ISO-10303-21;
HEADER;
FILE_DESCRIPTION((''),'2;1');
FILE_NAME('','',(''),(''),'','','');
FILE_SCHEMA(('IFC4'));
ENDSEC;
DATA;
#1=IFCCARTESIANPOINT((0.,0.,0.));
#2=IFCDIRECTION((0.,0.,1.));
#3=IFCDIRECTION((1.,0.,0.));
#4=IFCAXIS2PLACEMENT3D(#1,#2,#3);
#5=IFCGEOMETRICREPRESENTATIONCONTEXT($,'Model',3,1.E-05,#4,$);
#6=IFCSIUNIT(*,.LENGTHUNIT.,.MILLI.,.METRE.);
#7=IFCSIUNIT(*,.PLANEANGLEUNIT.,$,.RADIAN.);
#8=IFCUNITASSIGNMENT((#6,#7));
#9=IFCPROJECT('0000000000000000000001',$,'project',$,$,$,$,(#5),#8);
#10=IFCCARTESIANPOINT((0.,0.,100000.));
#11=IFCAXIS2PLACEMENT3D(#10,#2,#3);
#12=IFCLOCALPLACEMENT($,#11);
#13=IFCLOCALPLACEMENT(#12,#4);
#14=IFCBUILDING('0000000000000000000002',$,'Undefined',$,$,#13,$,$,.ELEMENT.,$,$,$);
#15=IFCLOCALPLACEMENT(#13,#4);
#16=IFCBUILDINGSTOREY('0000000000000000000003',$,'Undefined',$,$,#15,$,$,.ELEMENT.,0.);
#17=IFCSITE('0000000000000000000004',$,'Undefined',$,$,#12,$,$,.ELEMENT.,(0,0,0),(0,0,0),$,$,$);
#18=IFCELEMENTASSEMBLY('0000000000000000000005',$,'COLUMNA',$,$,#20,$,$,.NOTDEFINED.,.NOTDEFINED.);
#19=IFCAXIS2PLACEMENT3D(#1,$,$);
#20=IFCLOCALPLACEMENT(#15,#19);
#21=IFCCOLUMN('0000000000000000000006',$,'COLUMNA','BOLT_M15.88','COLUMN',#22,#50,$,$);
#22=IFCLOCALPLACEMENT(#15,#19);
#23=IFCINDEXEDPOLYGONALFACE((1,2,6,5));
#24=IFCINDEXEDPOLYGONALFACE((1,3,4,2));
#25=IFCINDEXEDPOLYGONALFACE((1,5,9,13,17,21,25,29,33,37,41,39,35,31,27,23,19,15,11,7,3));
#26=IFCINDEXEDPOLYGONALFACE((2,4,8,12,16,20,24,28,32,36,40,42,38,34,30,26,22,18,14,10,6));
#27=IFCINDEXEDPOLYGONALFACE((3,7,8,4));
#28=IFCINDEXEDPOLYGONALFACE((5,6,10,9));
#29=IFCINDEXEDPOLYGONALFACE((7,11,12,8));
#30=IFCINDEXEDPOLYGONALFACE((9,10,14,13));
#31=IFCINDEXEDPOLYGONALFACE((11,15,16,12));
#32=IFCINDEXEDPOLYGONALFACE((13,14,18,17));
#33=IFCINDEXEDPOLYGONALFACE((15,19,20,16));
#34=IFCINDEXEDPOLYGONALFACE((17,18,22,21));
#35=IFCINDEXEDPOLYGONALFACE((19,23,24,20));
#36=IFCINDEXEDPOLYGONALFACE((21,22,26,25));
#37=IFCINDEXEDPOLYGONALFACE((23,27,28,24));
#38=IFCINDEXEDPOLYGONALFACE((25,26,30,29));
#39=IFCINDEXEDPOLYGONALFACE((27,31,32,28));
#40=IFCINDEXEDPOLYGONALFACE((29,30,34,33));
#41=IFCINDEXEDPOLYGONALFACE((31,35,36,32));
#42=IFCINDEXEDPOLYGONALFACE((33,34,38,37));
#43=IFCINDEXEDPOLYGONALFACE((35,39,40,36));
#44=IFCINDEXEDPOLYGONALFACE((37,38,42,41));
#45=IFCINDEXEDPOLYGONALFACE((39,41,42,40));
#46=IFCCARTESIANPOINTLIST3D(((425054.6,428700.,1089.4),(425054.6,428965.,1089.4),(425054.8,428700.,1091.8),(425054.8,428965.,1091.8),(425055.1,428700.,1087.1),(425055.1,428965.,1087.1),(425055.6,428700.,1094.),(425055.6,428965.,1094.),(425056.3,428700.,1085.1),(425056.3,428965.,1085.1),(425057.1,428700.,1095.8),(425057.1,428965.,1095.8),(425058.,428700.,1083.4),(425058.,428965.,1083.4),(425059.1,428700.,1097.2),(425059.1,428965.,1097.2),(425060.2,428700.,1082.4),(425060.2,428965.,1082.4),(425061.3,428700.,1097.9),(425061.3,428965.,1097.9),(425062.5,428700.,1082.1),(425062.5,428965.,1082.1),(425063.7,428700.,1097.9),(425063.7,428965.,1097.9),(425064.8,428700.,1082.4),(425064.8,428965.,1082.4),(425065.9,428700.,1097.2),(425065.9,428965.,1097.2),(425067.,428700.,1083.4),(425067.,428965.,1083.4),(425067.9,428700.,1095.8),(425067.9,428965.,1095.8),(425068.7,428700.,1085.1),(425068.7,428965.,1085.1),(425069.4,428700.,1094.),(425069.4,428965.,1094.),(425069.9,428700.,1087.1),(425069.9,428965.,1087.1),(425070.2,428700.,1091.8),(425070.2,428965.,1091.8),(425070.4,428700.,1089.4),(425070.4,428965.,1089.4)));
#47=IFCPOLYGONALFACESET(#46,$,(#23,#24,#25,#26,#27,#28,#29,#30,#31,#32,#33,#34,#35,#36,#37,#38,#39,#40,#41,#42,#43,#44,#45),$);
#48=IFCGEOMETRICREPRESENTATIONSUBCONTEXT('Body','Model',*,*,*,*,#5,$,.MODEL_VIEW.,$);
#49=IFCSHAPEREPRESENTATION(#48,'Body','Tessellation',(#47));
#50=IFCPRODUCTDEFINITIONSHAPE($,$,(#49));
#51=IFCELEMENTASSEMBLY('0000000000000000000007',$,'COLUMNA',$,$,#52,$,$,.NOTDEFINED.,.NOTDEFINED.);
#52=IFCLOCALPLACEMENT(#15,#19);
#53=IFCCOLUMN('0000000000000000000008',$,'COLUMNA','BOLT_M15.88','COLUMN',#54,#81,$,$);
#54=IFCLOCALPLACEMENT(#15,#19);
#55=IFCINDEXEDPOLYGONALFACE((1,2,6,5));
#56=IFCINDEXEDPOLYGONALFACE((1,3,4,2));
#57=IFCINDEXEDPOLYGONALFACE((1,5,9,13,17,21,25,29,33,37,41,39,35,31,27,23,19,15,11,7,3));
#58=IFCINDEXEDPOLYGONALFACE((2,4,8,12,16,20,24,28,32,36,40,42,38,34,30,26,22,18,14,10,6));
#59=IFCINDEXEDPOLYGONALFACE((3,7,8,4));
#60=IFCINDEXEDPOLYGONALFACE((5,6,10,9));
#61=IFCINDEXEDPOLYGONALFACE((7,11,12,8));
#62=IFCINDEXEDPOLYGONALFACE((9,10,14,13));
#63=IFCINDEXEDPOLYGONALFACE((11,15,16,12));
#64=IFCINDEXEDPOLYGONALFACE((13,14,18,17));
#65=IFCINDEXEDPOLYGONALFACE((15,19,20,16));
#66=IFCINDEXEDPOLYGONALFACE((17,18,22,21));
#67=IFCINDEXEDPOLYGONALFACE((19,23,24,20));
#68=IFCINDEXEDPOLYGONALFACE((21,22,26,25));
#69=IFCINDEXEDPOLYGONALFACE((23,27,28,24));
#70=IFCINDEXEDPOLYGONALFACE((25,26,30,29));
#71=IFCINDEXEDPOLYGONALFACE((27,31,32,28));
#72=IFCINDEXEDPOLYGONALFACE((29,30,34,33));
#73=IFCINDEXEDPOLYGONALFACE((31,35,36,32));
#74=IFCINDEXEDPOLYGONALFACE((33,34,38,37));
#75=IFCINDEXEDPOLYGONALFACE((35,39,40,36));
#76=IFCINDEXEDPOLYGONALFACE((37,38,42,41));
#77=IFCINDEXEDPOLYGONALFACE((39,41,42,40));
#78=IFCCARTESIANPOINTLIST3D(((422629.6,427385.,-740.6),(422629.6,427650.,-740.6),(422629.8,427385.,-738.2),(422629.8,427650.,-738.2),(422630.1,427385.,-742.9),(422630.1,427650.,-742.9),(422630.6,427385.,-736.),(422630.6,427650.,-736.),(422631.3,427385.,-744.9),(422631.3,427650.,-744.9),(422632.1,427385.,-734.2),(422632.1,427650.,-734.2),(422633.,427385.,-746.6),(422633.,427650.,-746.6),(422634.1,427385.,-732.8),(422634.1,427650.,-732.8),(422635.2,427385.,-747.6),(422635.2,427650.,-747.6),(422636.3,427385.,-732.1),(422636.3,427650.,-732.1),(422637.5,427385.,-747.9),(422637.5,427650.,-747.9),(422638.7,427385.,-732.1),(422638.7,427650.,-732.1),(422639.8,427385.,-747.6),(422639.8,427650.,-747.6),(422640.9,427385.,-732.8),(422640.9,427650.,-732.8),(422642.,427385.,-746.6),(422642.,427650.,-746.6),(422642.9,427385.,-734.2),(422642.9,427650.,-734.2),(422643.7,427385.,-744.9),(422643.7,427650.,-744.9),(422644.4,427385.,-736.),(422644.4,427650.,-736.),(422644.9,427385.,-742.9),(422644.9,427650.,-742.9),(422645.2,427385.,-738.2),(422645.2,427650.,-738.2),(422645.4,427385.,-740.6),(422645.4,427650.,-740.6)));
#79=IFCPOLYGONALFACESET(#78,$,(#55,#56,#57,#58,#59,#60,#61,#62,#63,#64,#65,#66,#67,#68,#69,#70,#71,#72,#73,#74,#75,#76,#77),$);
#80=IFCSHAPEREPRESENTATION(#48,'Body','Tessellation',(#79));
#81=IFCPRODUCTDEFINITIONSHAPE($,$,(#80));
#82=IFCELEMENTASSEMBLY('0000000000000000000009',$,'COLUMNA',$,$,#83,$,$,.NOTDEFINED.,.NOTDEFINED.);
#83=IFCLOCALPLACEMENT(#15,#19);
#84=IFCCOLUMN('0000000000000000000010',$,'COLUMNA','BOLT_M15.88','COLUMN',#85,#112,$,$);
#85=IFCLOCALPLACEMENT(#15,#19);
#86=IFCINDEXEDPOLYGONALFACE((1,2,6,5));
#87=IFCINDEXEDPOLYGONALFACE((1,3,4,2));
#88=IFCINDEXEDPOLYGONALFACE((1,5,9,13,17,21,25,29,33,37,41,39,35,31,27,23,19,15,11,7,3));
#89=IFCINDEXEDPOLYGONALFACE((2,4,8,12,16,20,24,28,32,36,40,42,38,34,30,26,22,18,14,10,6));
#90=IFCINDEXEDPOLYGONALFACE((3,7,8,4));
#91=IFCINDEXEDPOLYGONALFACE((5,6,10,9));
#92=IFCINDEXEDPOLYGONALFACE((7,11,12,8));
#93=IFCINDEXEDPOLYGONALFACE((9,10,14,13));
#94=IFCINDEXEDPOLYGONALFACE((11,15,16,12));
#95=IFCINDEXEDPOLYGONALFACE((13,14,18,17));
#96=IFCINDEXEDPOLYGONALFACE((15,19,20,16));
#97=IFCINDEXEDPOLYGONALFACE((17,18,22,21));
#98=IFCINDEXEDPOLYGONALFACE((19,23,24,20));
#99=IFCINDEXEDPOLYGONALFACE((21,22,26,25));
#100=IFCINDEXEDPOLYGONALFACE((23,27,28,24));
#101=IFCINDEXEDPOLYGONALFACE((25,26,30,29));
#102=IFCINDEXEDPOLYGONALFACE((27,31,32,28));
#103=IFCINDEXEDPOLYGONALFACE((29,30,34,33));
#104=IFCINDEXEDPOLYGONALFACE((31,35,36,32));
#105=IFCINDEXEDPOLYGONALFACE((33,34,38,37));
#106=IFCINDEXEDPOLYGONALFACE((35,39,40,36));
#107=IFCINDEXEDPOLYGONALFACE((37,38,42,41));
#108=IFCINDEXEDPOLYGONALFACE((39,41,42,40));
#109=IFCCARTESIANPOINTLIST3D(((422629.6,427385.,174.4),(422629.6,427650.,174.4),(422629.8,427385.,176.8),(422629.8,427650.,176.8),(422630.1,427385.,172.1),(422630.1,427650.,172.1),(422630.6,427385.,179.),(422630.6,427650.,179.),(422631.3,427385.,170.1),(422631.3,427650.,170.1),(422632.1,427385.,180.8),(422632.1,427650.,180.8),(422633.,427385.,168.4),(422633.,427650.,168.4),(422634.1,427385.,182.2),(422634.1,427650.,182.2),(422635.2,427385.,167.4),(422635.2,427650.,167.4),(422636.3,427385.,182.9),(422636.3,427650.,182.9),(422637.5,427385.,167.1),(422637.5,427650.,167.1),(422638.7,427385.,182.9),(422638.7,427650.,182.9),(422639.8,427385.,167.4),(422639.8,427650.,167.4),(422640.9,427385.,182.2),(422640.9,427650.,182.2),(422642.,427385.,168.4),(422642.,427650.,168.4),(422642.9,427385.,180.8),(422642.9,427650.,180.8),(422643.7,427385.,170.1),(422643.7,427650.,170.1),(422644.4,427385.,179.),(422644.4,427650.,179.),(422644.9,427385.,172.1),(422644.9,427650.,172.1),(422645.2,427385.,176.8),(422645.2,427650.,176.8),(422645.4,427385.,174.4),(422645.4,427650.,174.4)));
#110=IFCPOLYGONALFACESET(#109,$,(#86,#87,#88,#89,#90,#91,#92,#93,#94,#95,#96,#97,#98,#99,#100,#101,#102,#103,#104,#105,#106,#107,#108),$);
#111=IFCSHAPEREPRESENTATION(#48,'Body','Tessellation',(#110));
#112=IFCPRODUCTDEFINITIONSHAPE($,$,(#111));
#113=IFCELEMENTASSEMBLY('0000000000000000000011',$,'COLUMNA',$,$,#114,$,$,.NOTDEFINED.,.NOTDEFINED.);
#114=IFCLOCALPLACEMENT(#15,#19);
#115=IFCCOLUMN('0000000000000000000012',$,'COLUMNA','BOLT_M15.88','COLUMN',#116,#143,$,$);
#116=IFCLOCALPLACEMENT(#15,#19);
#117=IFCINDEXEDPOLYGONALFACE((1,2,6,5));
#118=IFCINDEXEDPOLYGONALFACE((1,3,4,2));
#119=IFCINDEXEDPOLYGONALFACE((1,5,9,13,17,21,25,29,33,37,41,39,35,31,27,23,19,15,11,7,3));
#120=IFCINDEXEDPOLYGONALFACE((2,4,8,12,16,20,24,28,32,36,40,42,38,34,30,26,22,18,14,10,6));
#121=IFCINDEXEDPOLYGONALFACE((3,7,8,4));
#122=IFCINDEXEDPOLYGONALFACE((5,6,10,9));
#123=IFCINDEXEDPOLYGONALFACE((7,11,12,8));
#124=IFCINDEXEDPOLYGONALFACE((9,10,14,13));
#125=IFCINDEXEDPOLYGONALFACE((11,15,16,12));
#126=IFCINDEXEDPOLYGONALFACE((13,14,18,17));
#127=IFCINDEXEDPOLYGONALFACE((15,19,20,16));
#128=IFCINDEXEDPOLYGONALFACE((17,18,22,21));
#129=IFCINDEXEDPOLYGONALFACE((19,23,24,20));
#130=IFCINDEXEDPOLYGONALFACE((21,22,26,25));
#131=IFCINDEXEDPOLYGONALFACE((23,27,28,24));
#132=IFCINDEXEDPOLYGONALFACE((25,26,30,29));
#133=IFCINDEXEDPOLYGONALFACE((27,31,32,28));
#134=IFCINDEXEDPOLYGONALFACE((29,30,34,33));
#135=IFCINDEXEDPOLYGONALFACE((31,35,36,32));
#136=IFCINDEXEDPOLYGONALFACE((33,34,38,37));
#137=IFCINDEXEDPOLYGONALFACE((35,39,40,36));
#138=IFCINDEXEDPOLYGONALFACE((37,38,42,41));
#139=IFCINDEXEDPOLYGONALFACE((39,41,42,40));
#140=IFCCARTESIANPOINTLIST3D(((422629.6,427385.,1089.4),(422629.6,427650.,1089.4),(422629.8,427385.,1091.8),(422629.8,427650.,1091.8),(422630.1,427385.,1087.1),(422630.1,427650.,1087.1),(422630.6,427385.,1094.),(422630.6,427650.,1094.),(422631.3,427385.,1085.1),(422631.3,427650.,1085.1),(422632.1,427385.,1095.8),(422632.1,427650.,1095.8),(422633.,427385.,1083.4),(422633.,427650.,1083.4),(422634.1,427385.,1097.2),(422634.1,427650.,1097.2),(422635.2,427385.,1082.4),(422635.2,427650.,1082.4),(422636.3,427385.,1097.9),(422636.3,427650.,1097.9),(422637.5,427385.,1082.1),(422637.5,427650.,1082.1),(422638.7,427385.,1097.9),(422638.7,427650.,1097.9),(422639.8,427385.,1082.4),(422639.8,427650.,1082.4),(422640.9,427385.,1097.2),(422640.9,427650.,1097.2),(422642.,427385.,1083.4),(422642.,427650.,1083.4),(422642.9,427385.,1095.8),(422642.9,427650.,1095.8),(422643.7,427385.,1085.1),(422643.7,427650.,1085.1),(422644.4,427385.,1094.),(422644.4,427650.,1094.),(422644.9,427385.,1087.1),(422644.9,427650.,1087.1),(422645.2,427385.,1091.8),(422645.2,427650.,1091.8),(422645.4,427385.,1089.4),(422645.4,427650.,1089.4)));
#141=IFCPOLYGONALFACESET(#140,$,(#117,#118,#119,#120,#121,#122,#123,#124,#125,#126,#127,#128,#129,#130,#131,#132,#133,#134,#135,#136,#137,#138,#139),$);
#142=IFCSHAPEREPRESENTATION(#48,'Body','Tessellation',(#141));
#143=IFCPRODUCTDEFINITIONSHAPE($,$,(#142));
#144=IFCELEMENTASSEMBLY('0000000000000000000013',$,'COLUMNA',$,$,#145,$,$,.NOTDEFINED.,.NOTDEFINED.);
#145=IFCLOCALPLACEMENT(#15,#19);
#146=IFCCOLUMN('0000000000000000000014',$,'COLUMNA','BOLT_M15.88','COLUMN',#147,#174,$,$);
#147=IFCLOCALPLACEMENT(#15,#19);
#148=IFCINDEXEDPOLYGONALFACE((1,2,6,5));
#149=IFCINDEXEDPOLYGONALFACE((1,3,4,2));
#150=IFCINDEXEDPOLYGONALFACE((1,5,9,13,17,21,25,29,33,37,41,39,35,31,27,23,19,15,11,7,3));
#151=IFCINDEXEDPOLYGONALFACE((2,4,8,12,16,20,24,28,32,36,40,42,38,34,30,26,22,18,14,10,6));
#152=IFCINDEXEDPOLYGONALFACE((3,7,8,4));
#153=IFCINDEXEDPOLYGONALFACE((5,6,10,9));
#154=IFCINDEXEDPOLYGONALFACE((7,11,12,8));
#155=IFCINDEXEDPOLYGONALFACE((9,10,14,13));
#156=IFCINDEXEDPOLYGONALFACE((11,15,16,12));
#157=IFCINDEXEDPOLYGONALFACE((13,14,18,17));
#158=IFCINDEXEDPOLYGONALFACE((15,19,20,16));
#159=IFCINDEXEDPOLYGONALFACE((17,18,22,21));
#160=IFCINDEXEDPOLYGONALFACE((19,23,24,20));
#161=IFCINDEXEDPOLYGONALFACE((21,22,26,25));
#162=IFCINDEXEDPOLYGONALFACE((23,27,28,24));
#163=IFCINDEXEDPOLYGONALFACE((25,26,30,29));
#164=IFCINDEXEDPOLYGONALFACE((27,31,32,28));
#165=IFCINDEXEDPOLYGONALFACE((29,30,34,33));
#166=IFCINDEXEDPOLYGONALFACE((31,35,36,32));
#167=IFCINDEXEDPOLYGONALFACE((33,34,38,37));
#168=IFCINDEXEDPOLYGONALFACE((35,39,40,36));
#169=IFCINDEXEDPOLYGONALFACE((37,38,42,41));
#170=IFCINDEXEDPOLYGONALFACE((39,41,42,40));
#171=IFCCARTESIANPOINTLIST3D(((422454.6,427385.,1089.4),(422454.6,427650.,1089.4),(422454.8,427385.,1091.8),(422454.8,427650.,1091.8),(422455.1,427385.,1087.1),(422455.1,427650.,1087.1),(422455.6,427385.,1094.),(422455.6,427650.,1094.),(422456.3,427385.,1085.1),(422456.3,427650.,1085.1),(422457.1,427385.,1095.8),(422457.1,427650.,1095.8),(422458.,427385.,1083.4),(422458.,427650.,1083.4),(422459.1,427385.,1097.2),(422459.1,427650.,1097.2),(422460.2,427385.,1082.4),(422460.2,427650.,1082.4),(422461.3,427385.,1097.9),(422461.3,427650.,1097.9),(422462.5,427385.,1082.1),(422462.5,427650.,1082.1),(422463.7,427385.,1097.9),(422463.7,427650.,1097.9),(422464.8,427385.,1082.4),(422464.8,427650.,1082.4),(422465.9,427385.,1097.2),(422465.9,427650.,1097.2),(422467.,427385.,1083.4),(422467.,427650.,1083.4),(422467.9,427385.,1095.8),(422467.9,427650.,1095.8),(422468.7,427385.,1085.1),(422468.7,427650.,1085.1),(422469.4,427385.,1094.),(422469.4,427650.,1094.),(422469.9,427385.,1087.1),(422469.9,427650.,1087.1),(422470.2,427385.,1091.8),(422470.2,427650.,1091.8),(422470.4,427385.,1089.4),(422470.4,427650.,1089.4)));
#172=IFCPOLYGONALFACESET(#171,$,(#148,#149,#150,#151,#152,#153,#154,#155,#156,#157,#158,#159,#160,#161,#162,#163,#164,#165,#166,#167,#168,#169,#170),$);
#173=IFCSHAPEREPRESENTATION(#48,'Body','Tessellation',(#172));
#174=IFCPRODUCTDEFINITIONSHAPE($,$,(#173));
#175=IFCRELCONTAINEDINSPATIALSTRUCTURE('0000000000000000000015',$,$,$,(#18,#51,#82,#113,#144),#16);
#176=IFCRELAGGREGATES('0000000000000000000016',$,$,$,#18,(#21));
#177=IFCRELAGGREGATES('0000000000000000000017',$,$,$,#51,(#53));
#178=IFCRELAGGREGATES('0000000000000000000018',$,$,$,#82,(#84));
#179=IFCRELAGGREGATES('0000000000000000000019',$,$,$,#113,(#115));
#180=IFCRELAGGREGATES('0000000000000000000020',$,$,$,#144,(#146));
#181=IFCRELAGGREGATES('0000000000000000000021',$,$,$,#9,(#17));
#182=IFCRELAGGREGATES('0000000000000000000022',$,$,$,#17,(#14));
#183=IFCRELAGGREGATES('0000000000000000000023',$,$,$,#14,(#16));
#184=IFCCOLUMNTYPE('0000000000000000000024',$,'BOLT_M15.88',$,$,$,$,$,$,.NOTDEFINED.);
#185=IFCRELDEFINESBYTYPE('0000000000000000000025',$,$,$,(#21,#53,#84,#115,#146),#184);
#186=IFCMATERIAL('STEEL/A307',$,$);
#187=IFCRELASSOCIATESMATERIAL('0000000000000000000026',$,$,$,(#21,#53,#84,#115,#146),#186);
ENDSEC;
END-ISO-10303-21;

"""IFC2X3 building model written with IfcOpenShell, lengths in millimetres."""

from ifc_helpers import new_model, si_unit, frame, origin_with_axes, origin_2d_with_axis, place, context, subcontext, project, spatial, circle, extrude, material, type_object, element, aggregate, save


model = new_model("IFC2X3")

# Units and contexts
model_context = context("Model", 3, precision=1e-05, world=origin_with_axes())
body_context = subcontext(model_context, "Body", "Model", "MODEL_VIEW")
ifc_project = project(units=[si_unit("LENGTHUNIT", "METRE", prefix="MILLI"), si_unit("PLANEANGLEUNIT", "RADIAN")], contexts=[model_context])

# Site, building, storey
site_placement = place(None, frame((0.0, 0.0, 100000.0), z_axis=(0.0, 0.0, 1.0), x_axis=(1.0, 0.0, 0.0)))
site = spatial("IfcSite", under=ifc_project, at=site_placement, Name="Undefined", CompositionType="ELEMENT", RefLatitude=(0, 0, 0), RefLongitude=(0, 0, 0))
building_placement = place(site_placement, origin_with_axes())
building = spatial("IfcBuilding", under=site, at=building_placement, Name="Undefined", CompositionType="ELEMENT")
storey_placement = place(building_placement, origin_with_axes())
storey = spatial("IfcBuildingStorey", under=building, at=storey_placement, Name="Undefined", CompositionType="ELEMENT", Elevation=0.0)

# Element assemblies, columns
ifc_material = material(Name="STEEL/A307")
column_type_1 = type_object("IfcColumnType", Name="BOLT_M15.88", PredefinedType="NOTDEFINED")
assembly_1_placement = place(storey_placement, origin_with_axes())
assembly_1 = element("IfcElementAssembly", 1, at=assembly_1_placement, inside=storey, Name="COLUMNA", AssemblyPlace="NOTDEFINED", PredefinedType="NOTDEFINED")
column_1_placement = place(assembly_1_placement, frame((425062.5, 428700.0, 1090.0), z_axis=(0.0, 1.0, -0.000003), x_axis=(1.0, 0.0, 0.0)))
column_1 = element("IfcColumn", 2, at=column_1_placement, type_object=column_type_1, material=ifc_material, Name="COLUMNA", Description="BOLT_M15.88", ObjectType="COLUMN", context=body_context, shape_type="SweptSolid", body=[
    extrude(circle(Radius=7.9, at=origin_2d_with_axis()), frame((0.0, 0.0, 265.0), z_axis=(0.0, 0.0, -1.0), x_axis=(0.0, 1.0, 0.0)), (0.0, 0.0, 1.0), 265.0),
])
aggregate(assembly_1, [column_1])
assembly_2_placement = place(storey_placement, origin_with_axes())
assembly_2 = element("IfcElementAssembly", 3, at=assembly_2_placement, inside=storey, Name="COLUMNA", AssemblyPlace="NOTDEFINED", PredefinedType="NOTDEFINED")
column_2_placement = place(assembly_2_placement, frame((422637.5, 427650.0, -740.0), z_axis=(0.0, -1.0, -0.000003), x_axis=(-1.0, 0.0, 0.0)))
column_2 = element("IfcColumn", 4, at=column_2_placement, type_object=column_type_1, material=ifc_material, Name="COLUMNA", Description="BOLT_M15.88", ObjectType="COLUMN", context=body_context, shape_type="SweptSolid", body=[
    extrude(circle(Radius=7.9, at=origin_2d_with_axis()), frame((0.0, 0.0, 265.0), z_axis=(0.0, 0.0, -1.0), x_axis=(0.0, 1.0, 0.0)), (0.0, 0.0, 1.0), 265.0),
])
aggregate(assembly_2, [column_2])
assembly_3_placement = place(storey_placement, origin_with_axes())
assembly_3 = element("IfcElementAssembly", 5, at=assembly_3_placement, inside=storey, Name="COLUMNA", AssemblyPlace="NOTDEFINED", PredefinedType="NOTDEFINED")
column_3_placement = place(assembly_3_placement, frame((422637.5, 427650.0, 175.0), z_axis=(0.0, -1.0, -0.000003), x_axis=(-1.0, 0.0, 0.0)))
column_3 = element("IfcColumn", 6, at=column_3_placement, type_object=column_type_1, material=ifc_material, Name="COLUMNA", Description="BOLT_M15.88", ObjectType="COLUMN", context=body_context, shape_type="SweptSolid", body=[
    extrude(circle(Radius=7.9, at=origin_2d_with_axis()), frame((0.0, 0.0, 265.0), z_axis=(0.0, 0.0, -1.0), x_axis=(0.0, 1.0, 0.0)), (0.0, 0.0, 1.0), 265.0),
])
aggregate(assembly_3, [column_3])
assembly_4_placement = place(storey_placement, origin_with_axes())
assembly_4 = element("IfcElementAssembly", 7, at=assembly_4_placement, inside=storey, Name="COLUMNA", AssemblyPlace="NOTDEFINED", PredefinedType="NOTDEFINED")
column_4_placement = place(assembly_4_placement, frame((422637.5, 427650.0, 1090.0), z_axis=(0.0, -1.0, -0.000003), x_axis=(-1.0, 0.0, 0.0)))
column_4 = element("IfcColumn", 8, at=column_4_placement, type_object=column_type_1, material=ifc_material, Name="COLUMNA", Description="BOLT_M15.88", ObjectType="COLUMN", context=body_context, shape_type="SweptSolid", body=[
    extrude(circle(Radius=7.9, at=origin_2d_with_axis()), frame((0.0, 0.0, 265.0), z_axis=(0.0, 0.0, -1.0), x_axis=(0.0, 1.0, 0.0)), (0.0, 0.0, 1.0), 265.0),
])
aggregate(assembly_4, [column_4])
assembly_5_placement = place(storey_placement, origin_with_axes())
assembly_5 = element("IfcElementAssembly", 9, at=assembly_5_placement, inside=storey, Name="COLUMNA", AssemblyPlace="NOTDEFINED", PredefinedType="NOTDEFINED")
column_5_placement = place(assembly_5_placement, frame((422462.5, 427650.0, 1090.0), z_axis=(0.0, -1.0, -0.000003), x_axis=(-1.0, 0.0, 0.0)))
column_5 = element("IfcColumn", 10, at=column_5_placement, type_object=column_type_1, material=ifc_material, Name="COLUMNA", Description="BOLT_M15.88", ObjectType="COLUMN", context=body_context, shape_type="SweptSolid", body=[
    extrude(circle(Radius=7.9, at=origin_2d_with_axis()), frame((0.0, 0.0, 265.0), z_axis=(0.0, 0.0, -1.0), x_axis=(0.0, 1.0, 0.0)), (0.0, 0.0, 1.0), 265.0),
])
aggregate(assembly_5, [column_5])

save(model, "model.ifc")
